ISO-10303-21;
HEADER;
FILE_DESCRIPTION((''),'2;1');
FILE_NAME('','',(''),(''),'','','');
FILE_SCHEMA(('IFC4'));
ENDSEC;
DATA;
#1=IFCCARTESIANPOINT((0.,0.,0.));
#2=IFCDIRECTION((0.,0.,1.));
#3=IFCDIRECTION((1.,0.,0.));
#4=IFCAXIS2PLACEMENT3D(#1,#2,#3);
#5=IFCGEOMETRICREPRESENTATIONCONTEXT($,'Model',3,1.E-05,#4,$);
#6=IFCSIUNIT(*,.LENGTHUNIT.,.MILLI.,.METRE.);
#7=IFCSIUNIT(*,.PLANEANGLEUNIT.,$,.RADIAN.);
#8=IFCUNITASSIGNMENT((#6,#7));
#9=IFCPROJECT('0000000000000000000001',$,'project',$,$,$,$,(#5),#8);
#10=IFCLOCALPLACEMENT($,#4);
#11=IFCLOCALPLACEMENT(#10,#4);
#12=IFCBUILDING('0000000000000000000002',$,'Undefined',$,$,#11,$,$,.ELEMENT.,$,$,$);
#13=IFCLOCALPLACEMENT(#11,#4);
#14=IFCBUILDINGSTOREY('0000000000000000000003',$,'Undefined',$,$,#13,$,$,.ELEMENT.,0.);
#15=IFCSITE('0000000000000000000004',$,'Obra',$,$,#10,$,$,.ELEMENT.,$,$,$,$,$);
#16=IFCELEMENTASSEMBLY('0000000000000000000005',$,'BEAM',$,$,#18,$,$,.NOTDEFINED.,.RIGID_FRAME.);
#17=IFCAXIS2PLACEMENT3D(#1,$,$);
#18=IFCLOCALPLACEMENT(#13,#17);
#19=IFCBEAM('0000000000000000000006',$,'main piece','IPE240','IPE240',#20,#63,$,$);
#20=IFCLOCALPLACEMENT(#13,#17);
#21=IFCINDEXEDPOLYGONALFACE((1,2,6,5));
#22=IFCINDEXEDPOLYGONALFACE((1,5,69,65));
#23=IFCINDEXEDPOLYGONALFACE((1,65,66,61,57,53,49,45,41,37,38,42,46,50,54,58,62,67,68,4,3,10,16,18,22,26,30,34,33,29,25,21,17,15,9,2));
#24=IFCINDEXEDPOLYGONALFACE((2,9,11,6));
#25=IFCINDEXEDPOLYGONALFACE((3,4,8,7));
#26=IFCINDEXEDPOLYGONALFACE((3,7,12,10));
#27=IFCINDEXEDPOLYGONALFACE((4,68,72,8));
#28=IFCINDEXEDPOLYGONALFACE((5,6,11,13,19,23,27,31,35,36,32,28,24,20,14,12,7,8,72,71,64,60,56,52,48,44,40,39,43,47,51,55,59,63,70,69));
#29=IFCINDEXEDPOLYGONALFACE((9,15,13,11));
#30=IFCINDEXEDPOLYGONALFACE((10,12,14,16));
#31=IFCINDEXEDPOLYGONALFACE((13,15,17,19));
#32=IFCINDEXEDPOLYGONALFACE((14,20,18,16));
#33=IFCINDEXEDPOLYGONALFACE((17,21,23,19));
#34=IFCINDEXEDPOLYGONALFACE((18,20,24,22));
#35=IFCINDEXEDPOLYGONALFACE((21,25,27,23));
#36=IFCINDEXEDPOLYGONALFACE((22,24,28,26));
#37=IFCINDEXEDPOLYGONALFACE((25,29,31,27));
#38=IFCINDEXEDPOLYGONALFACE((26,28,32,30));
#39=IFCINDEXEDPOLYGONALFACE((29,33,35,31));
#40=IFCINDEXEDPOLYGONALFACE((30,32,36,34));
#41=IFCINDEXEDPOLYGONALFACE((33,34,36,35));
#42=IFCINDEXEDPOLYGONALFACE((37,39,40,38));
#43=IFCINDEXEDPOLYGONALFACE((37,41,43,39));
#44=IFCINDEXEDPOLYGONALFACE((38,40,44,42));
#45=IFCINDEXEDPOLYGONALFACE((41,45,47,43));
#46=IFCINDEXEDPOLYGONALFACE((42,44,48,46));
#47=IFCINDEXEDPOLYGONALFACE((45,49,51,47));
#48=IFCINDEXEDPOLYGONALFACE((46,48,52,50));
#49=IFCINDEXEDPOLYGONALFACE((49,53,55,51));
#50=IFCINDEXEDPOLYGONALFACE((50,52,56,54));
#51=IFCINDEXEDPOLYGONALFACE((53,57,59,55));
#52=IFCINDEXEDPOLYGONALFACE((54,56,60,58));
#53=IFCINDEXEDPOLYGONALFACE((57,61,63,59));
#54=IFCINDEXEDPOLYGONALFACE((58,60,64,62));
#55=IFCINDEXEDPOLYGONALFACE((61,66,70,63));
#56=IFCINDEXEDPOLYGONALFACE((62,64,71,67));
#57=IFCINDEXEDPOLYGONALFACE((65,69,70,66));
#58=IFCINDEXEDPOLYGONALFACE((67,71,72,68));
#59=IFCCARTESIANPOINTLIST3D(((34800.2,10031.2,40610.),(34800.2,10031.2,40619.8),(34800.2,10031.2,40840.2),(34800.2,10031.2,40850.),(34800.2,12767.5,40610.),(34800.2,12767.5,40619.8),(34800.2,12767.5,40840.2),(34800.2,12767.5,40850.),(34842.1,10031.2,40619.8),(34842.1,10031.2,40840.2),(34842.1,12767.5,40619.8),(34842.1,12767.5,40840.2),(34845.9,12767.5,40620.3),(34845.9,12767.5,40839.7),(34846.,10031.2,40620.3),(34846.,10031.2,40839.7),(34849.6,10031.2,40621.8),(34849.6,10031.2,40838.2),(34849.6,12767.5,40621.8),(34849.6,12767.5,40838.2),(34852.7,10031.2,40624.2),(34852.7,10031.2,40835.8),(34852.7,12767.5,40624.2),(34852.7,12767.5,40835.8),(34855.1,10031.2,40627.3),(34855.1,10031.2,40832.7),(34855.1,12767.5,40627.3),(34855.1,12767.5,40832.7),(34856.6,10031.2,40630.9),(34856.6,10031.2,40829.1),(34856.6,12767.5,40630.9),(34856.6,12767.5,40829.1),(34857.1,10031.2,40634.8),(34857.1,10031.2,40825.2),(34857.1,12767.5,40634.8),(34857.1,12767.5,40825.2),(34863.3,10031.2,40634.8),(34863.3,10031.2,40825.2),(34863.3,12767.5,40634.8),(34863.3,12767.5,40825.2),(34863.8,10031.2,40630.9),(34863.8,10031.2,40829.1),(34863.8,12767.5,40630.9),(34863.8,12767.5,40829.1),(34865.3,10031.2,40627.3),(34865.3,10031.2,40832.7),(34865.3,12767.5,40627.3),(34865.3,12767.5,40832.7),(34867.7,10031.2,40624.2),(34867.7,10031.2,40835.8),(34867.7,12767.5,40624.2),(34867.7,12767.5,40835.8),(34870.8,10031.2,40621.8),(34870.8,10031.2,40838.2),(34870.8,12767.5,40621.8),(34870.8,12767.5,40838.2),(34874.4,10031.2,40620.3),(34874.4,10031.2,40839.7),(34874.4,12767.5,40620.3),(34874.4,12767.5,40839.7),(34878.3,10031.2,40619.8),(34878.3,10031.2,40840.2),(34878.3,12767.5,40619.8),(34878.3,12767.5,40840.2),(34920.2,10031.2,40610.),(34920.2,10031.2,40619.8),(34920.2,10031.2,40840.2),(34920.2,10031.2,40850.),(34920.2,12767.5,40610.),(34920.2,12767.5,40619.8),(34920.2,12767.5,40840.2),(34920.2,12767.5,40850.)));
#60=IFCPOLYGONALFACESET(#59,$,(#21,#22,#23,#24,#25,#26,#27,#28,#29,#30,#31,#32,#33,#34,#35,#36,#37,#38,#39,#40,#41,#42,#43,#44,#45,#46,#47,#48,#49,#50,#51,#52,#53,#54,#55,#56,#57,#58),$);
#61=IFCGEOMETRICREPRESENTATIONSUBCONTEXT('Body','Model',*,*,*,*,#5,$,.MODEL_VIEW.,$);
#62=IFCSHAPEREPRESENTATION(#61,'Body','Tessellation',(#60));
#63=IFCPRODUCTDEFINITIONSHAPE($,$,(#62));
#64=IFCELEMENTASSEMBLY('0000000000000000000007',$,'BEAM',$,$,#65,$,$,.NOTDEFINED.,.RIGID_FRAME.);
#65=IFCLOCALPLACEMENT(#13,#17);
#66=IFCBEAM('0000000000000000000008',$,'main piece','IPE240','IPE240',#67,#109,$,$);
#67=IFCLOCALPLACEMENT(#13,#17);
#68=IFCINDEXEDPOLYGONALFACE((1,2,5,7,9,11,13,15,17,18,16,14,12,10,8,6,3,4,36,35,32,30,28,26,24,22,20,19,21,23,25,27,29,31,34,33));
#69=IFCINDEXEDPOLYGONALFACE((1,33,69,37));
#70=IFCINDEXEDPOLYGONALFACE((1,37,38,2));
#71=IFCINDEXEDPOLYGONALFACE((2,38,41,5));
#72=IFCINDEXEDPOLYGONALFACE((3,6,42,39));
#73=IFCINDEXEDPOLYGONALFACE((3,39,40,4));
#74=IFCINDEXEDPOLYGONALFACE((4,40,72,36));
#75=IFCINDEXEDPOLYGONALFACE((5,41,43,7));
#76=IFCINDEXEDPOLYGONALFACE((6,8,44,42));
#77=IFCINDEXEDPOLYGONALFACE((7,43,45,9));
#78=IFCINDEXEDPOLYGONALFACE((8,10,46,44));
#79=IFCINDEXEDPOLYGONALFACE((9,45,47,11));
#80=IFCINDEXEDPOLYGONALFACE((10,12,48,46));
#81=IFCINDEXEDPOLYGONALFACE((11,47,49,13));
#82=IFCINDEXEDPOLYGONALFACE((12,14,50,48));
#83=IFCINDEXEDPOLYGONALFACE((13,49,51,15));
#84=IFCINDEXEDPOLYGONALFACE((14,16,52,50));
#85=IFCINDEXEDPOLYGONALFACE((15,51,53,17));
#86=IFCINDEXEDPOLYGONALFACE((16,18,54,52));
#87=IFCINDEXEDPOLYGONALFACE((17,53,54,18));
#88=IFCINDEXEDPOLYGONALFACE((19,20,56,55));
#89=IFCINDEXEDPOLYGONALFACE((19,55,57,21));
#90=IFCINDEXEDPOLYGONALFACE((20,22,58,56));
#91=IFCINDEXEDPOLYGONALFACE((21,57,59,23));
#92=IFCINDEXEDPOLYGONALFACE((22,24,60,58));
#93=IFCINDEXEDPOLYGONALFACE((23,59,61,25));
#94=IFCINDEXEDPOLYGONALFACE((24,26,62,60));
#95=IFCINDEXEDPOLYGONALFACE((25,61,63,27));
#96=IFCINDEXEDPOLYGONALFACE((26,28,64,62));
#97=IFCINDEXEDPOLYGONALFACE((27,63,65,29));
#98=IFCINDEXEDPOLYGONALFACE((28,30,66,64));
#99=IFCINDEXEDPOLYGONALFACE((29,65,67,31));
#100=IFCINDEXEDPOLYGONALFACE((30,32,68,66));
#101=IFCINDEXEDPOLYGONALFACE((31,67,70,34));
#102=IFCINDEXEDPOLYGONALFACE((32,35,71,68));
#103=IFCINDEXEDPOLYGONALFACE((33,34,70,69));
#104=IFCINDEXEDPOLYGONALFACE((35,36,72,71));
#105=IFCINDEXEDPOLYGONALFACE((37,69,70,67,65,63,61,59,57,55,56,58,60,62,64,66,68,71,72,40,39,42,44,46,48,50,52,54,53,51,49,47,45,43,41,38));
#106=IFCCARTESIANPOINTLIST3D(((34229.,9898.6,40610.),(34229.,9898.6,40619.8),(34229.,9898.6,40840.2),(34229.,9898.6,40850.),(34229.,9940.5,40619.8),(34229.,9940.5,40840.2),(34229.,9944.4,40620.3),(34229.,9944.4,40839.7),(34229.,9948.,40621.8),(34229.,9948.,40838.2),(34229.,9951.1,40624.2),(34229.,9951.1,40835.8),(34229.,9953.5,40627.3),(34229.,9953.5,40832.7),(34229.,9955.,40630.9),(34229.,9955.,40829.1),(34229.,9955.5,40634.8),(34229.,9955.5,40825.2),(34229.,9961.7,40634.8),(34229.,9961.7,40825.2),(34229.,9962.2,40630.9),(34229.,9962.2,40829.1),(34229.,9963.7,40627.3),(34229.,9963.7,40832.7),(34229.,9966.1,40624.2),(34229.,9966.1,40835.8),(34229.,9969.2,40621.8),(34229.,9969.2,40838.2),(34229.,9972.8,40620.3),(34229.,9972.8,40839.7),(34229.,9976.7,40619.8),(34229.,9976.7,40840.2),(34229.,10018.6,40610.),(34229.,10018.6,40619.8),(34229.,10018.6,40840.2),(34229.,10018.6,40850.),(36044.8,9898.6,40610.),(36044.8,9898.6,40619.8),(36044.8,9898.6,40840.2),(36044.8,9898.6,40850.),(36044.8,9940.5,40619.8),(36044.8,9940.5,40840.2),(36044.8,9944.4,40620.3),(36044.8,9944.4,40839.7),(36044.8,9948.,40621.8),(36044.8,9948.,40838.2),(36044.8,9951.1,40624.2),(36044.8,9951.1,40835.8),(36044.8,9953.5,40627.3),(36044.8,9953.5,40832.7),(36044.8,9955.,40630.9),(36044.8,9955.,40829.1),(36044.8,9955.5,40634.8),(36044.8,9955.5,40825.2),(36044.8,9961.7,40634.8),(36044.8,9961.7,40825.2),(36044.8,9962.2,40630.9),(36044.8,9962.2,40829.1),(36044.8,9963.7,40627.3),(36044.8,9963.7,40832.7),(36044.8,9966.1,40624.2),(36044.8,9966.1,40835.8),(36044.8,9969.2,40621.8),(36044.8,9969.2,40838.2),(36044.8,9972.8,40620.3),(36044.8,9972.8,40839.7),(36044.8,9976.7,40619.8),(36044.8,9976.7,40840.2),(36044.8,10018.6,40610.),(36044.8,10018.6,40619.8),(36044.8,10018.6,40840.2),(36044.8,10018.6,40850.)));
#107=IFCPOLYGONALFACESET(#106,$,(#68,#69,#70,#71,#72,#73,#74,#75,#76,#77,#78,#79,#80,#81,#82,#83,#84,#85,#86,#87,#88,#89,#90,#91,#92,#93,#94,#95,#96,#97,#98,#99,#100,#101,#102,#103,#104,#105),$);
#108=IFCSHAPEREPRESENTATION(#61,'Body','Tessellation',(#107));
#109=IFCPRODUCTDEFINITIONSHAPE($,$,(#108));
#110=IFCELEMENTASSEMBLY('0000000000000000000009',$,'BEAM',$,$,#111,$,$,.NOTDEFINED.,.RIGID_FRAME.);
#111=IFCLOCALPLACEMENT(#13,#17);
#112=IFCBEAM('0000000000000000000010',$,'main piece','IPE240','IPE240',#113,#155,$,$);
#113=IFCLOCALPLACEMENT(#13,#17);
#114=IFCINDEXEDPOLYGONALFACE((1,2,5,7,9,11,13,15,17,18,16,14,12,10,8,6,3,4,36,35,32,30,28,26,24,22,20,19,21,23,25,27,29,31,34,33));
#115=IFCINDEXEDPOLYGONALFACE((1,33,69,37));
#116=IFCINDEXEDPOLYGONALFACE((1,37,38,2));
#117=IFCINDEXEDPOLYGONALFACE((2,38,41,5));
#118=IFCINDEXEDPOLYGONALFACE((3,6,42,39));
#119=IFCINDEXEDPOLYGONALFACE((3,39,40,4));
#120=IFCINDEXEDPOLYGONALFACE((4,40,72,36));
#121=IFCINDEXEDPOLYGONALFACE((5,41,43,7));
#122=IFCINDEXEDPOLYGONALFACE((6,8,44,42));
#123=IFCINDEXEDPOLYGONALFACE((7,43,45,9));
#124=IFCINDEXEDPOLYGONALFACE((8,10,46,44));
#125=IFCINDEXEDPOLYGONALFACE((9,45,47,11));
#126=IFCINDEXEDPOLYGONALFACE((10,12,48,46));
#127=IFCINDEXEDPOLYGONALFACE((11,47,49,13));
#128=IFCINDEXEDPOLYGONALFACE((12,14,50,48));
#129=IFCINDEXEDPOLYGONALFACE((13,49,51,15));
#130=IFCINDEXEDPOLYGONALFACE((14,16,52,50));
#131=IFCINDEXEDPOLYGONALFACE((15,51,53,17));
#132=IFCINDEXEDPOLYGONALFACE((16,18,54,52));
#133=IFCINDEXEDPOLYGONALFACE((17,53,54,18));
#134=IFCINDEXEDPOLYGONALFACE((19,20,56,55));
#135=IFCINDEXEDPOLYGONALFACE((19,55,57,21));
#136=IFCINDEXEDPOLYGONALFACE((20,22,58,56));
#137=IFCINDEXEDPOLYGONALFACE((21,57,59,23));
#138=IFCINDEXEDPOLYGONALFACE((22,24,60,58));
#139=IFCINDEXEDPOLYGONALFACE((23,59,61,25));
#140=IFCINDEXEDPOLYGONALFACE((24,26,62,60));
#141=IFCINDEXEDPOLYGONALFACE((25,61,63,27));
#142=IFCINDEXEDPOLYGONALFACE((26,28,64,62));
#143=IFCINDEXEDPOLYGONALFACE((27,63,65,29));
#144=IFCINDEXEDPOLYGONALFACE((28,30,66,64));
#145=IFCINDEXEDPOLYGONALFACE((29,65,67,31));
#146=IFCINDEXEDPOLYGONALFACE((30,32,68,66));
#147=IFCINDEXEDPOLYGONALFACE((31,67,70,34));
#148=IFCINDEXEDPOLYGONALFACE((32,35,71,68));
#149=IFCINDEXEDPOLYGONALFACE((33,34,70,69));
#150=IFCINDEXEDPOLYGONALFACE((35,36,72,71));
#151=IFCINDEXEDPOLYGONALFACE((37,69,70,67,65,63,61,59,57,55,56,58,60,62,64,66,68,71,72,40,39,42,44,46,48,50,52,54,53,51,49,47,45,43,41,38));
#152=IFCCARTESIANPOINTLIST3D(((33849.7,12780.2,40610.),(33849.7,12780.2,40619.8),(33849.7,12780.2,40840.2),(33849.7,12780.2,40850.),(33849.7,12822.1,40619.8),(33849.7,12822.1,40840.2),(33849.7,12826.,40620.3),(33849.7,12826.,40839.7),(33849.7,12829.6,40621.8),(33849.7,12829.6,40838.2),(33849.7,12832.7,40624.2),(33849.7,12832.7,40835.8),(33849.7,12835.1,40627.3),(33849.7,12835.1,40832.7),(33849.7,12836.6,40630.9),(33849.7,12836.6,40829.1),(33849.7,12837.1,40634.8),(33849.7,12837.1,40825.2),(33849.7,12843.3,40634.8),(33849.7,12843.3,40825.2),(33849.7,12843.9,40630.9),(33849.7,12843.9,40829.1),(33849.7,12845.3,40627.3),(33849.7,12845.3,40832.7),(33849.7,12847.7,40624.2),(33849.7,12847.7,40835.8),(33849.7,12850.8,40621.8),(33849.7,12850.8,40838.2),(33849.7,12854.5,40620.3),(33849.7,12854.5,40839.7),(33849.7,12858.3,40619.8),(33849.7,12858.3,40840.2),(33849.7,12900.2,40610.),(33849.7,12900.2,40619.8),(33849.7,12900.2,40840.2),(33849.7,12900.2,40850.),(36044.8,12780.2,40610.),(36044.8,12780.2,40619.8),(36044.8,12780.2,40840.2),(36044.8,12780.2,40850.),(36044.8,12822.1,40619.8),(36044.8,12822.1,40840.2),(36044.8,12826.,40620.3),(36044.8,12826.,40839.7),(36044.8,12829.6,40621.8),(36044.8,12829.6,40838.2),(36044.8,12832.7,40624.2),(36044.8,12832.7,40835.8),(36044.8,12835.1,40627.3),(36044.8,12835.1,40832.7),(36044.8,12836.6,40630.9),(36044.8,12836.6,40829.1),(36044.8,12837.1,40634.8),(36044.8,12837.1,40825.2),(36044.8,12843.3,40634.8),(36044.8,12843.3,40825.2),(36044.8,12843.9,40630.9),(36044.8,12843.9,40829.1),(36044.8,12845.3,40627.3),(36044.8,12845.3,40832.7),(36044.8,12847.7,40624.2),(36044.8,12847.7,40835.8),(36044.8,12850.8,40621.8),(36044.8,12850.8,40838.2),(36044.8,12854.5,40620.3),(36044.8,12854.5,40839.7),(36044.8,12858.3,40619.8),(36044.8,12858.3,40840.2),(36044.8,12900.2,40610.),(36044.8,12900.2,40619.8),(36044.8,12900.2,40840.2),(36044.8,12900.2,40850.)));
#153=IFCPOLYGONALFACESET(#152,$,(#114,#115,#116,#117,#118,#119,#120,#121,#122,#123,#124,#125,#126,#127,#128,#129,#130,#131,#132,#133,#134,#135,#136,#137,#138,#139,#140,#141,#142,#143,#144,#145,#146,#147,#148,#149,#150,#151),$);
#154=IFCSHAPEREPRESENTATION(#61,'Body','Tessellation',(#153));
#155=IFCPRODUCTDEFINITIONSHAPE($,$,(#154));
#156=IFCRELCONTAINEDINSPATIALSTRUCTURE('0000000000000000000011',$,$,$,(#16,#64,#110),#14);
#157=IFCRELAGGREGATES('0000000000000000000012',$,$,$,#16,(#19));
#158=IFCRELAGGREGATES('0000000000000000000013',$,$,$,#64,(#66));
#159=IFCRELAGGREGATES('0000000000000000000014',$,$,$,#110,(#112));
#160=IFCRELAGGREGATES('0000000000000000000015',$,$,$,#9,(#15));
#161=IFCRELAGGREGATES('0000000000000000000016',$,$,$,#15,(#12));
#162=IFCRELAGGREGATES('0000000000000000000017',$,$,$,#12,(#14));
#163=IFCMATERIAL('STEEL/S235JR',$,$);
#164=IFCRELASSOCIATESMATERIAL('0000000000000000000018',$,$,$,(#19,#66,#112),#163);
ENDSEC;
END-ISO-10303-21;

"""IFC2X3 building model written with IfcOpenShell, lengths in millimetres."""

from ifc_helpers import new_model, si_unit, frame, origin_with_axes, origin_2d_with_axis, place, context, subcontext, project, spatial, i_section, extrude, material, element, aggregate, save


model = new_model("IFC2X3")

# Units and contexts
model_context = context("Model", 3, precision=1e-05, world=origin_with_axes())
body_context = subcontext(model_context, "Body", "Model", "MODEL_VIEW")
ifc_project = project(units=[si_unit("LENGTHUNIT", "METRE", prefix="MILLI"), si_unit("PLANEANGLEUNIT", "RADIAN")], contexts=[model_context])

# Site, building, storey
site_placement = place(None, origin_with_axes())
site = spatial("IfcSite", under=ifc_project, at=site_placement, Name="Obra", CompositionType="ELEMENT")
building_placement = place(site_placement, origin_with_axes())
building = spatial("IfcBuilding", under=site, at=building_placement, Name="Undefined", CompositionType="ELEMENT")
storey_placement = place(building_placement, origin_with_axes())
storey = spatial("IfcBuildingStorey", under=building, at=storey_placement, Name="Undefined", CompositionType="ELEMENT", Elevation=0.0)

# Element assemblies, beams
ifc_material_1 = material(Name="STEEL/S235JR")
assembly_1_placement = place(storey_placement, origin_with_axes())
assembly_1 = element("IfcElementAssembly", 1, at=assembly_1_placement, inside=storey, Name="BEAM", AssemblyPlace="NOTDEFINED", PredefinedType="RIGID_FRAME")
beam_1_placement = place(assembly_1_placement, frame((34860.2, 10031.2, 40730.0), z_axis=(0.0, 0.0, 1.0), x_axis=(-0.000002, 1.0, 0.0)))
beam_1 = element("IfcBeam", 2, at=beam_1_placement, material=ifc_material_1, Name="main piece", Description="IPE240", ObjectType="IPE240", context=body_context, shape_type="SweptSolid", body=[
    extrude(i_section(OverallWidth=120.0, OverallDepth=240.0, WebThickness=6.2, FlangeThickness=9.8, FilletRadius=15.0, at=origin_2d_with_axis()), frame((2736.3, 0.0, 0.0), z_axis=(-1.0, 0.0, 0.0), x_axis=(0.0, -1.0, 0.0)), (0.0, 0.0, 1.0), 2736.3),
])
aggregate(assembly_1, [beam_1])
assembly_2_placement = place(storey_placement, origin_with_axes())
assembly_2 = element("IfcElementAssembly", 3, at=assembly_2_placement, inside=storey, Name="BEAM", AssemblyPlace="NOTDEFINED", PredefinedType="RIGID_FRAME")
beam_2_placement = place(assembly_2_placement, frame((34229.0, 9958.6, 40730.0), z_axis=(0.0, 0.0, 1.0), x_axis=(1.0, 0.0, 0.0)))
beam_2 = element("IfcBeam", 4, at=beam_2_placement, material=ifc_material_1, Name="main piece", Description="IPE240", ObjectType="IPE240", context=body_context, shape_type="SweptSolid", body=[
    extrude(i_section(OverallWidth=120.0, OverallDepth=240.0, WebThickness=6.2, FlangeThickness=9.8, FilletRadius=15.0, at=origin_2d_with_axis()), frame((1815.8, 0.0, 0.0), z_axis=(-1.0, 0.0, 0.0), x_axis=(0.0, -1.0, 0.0)), (0.0, 0.0, 1.0), 1815.8),
])
aggregate(assembly_2, [beam_2])
assembly_3_placement = place(storey_placement, origin_with_axes())
assembly_3 = element("IfcElementAssembly", 5, at=assembly_3_placement, inside=storey, Name="BEAM", AssemblyPlace="NOTDEFINED", PredefinedType="RIGID_FRAME")
beam_3_placement = place(assembly_3_placement, frame((33849.7, 12840.2, 40730.0), z_axis=(0.0, 0.0, 1.0), x_axis=(1.0, 0.0, 0.0)))
beam_3 = element("IfcBeam", 6, at=beam_3_placement, material=ifc_material_1, Name="main piece", Description="IPE240", ObjectType="IPE240", context=body_context, shape_type="SweptSolid", body=[
    extrude(i_section(OverallWidth=120.0, OverallDepth=240.0, WebThickness=6.2, FlangeThickness=9.8, FilletRadius=15.0, at=origin_2d_with_axis()), frame((2195.1, 0.0, 0.0), z_axis=(-1.0, 0.0, 0.0), x_axis=(0.0, -1.0, 0.0)), (0.0, 0.0, 1.0), 2195.1),
])
aggregate(assembly_3, [beam_3])

save(model, "model.ifc")
